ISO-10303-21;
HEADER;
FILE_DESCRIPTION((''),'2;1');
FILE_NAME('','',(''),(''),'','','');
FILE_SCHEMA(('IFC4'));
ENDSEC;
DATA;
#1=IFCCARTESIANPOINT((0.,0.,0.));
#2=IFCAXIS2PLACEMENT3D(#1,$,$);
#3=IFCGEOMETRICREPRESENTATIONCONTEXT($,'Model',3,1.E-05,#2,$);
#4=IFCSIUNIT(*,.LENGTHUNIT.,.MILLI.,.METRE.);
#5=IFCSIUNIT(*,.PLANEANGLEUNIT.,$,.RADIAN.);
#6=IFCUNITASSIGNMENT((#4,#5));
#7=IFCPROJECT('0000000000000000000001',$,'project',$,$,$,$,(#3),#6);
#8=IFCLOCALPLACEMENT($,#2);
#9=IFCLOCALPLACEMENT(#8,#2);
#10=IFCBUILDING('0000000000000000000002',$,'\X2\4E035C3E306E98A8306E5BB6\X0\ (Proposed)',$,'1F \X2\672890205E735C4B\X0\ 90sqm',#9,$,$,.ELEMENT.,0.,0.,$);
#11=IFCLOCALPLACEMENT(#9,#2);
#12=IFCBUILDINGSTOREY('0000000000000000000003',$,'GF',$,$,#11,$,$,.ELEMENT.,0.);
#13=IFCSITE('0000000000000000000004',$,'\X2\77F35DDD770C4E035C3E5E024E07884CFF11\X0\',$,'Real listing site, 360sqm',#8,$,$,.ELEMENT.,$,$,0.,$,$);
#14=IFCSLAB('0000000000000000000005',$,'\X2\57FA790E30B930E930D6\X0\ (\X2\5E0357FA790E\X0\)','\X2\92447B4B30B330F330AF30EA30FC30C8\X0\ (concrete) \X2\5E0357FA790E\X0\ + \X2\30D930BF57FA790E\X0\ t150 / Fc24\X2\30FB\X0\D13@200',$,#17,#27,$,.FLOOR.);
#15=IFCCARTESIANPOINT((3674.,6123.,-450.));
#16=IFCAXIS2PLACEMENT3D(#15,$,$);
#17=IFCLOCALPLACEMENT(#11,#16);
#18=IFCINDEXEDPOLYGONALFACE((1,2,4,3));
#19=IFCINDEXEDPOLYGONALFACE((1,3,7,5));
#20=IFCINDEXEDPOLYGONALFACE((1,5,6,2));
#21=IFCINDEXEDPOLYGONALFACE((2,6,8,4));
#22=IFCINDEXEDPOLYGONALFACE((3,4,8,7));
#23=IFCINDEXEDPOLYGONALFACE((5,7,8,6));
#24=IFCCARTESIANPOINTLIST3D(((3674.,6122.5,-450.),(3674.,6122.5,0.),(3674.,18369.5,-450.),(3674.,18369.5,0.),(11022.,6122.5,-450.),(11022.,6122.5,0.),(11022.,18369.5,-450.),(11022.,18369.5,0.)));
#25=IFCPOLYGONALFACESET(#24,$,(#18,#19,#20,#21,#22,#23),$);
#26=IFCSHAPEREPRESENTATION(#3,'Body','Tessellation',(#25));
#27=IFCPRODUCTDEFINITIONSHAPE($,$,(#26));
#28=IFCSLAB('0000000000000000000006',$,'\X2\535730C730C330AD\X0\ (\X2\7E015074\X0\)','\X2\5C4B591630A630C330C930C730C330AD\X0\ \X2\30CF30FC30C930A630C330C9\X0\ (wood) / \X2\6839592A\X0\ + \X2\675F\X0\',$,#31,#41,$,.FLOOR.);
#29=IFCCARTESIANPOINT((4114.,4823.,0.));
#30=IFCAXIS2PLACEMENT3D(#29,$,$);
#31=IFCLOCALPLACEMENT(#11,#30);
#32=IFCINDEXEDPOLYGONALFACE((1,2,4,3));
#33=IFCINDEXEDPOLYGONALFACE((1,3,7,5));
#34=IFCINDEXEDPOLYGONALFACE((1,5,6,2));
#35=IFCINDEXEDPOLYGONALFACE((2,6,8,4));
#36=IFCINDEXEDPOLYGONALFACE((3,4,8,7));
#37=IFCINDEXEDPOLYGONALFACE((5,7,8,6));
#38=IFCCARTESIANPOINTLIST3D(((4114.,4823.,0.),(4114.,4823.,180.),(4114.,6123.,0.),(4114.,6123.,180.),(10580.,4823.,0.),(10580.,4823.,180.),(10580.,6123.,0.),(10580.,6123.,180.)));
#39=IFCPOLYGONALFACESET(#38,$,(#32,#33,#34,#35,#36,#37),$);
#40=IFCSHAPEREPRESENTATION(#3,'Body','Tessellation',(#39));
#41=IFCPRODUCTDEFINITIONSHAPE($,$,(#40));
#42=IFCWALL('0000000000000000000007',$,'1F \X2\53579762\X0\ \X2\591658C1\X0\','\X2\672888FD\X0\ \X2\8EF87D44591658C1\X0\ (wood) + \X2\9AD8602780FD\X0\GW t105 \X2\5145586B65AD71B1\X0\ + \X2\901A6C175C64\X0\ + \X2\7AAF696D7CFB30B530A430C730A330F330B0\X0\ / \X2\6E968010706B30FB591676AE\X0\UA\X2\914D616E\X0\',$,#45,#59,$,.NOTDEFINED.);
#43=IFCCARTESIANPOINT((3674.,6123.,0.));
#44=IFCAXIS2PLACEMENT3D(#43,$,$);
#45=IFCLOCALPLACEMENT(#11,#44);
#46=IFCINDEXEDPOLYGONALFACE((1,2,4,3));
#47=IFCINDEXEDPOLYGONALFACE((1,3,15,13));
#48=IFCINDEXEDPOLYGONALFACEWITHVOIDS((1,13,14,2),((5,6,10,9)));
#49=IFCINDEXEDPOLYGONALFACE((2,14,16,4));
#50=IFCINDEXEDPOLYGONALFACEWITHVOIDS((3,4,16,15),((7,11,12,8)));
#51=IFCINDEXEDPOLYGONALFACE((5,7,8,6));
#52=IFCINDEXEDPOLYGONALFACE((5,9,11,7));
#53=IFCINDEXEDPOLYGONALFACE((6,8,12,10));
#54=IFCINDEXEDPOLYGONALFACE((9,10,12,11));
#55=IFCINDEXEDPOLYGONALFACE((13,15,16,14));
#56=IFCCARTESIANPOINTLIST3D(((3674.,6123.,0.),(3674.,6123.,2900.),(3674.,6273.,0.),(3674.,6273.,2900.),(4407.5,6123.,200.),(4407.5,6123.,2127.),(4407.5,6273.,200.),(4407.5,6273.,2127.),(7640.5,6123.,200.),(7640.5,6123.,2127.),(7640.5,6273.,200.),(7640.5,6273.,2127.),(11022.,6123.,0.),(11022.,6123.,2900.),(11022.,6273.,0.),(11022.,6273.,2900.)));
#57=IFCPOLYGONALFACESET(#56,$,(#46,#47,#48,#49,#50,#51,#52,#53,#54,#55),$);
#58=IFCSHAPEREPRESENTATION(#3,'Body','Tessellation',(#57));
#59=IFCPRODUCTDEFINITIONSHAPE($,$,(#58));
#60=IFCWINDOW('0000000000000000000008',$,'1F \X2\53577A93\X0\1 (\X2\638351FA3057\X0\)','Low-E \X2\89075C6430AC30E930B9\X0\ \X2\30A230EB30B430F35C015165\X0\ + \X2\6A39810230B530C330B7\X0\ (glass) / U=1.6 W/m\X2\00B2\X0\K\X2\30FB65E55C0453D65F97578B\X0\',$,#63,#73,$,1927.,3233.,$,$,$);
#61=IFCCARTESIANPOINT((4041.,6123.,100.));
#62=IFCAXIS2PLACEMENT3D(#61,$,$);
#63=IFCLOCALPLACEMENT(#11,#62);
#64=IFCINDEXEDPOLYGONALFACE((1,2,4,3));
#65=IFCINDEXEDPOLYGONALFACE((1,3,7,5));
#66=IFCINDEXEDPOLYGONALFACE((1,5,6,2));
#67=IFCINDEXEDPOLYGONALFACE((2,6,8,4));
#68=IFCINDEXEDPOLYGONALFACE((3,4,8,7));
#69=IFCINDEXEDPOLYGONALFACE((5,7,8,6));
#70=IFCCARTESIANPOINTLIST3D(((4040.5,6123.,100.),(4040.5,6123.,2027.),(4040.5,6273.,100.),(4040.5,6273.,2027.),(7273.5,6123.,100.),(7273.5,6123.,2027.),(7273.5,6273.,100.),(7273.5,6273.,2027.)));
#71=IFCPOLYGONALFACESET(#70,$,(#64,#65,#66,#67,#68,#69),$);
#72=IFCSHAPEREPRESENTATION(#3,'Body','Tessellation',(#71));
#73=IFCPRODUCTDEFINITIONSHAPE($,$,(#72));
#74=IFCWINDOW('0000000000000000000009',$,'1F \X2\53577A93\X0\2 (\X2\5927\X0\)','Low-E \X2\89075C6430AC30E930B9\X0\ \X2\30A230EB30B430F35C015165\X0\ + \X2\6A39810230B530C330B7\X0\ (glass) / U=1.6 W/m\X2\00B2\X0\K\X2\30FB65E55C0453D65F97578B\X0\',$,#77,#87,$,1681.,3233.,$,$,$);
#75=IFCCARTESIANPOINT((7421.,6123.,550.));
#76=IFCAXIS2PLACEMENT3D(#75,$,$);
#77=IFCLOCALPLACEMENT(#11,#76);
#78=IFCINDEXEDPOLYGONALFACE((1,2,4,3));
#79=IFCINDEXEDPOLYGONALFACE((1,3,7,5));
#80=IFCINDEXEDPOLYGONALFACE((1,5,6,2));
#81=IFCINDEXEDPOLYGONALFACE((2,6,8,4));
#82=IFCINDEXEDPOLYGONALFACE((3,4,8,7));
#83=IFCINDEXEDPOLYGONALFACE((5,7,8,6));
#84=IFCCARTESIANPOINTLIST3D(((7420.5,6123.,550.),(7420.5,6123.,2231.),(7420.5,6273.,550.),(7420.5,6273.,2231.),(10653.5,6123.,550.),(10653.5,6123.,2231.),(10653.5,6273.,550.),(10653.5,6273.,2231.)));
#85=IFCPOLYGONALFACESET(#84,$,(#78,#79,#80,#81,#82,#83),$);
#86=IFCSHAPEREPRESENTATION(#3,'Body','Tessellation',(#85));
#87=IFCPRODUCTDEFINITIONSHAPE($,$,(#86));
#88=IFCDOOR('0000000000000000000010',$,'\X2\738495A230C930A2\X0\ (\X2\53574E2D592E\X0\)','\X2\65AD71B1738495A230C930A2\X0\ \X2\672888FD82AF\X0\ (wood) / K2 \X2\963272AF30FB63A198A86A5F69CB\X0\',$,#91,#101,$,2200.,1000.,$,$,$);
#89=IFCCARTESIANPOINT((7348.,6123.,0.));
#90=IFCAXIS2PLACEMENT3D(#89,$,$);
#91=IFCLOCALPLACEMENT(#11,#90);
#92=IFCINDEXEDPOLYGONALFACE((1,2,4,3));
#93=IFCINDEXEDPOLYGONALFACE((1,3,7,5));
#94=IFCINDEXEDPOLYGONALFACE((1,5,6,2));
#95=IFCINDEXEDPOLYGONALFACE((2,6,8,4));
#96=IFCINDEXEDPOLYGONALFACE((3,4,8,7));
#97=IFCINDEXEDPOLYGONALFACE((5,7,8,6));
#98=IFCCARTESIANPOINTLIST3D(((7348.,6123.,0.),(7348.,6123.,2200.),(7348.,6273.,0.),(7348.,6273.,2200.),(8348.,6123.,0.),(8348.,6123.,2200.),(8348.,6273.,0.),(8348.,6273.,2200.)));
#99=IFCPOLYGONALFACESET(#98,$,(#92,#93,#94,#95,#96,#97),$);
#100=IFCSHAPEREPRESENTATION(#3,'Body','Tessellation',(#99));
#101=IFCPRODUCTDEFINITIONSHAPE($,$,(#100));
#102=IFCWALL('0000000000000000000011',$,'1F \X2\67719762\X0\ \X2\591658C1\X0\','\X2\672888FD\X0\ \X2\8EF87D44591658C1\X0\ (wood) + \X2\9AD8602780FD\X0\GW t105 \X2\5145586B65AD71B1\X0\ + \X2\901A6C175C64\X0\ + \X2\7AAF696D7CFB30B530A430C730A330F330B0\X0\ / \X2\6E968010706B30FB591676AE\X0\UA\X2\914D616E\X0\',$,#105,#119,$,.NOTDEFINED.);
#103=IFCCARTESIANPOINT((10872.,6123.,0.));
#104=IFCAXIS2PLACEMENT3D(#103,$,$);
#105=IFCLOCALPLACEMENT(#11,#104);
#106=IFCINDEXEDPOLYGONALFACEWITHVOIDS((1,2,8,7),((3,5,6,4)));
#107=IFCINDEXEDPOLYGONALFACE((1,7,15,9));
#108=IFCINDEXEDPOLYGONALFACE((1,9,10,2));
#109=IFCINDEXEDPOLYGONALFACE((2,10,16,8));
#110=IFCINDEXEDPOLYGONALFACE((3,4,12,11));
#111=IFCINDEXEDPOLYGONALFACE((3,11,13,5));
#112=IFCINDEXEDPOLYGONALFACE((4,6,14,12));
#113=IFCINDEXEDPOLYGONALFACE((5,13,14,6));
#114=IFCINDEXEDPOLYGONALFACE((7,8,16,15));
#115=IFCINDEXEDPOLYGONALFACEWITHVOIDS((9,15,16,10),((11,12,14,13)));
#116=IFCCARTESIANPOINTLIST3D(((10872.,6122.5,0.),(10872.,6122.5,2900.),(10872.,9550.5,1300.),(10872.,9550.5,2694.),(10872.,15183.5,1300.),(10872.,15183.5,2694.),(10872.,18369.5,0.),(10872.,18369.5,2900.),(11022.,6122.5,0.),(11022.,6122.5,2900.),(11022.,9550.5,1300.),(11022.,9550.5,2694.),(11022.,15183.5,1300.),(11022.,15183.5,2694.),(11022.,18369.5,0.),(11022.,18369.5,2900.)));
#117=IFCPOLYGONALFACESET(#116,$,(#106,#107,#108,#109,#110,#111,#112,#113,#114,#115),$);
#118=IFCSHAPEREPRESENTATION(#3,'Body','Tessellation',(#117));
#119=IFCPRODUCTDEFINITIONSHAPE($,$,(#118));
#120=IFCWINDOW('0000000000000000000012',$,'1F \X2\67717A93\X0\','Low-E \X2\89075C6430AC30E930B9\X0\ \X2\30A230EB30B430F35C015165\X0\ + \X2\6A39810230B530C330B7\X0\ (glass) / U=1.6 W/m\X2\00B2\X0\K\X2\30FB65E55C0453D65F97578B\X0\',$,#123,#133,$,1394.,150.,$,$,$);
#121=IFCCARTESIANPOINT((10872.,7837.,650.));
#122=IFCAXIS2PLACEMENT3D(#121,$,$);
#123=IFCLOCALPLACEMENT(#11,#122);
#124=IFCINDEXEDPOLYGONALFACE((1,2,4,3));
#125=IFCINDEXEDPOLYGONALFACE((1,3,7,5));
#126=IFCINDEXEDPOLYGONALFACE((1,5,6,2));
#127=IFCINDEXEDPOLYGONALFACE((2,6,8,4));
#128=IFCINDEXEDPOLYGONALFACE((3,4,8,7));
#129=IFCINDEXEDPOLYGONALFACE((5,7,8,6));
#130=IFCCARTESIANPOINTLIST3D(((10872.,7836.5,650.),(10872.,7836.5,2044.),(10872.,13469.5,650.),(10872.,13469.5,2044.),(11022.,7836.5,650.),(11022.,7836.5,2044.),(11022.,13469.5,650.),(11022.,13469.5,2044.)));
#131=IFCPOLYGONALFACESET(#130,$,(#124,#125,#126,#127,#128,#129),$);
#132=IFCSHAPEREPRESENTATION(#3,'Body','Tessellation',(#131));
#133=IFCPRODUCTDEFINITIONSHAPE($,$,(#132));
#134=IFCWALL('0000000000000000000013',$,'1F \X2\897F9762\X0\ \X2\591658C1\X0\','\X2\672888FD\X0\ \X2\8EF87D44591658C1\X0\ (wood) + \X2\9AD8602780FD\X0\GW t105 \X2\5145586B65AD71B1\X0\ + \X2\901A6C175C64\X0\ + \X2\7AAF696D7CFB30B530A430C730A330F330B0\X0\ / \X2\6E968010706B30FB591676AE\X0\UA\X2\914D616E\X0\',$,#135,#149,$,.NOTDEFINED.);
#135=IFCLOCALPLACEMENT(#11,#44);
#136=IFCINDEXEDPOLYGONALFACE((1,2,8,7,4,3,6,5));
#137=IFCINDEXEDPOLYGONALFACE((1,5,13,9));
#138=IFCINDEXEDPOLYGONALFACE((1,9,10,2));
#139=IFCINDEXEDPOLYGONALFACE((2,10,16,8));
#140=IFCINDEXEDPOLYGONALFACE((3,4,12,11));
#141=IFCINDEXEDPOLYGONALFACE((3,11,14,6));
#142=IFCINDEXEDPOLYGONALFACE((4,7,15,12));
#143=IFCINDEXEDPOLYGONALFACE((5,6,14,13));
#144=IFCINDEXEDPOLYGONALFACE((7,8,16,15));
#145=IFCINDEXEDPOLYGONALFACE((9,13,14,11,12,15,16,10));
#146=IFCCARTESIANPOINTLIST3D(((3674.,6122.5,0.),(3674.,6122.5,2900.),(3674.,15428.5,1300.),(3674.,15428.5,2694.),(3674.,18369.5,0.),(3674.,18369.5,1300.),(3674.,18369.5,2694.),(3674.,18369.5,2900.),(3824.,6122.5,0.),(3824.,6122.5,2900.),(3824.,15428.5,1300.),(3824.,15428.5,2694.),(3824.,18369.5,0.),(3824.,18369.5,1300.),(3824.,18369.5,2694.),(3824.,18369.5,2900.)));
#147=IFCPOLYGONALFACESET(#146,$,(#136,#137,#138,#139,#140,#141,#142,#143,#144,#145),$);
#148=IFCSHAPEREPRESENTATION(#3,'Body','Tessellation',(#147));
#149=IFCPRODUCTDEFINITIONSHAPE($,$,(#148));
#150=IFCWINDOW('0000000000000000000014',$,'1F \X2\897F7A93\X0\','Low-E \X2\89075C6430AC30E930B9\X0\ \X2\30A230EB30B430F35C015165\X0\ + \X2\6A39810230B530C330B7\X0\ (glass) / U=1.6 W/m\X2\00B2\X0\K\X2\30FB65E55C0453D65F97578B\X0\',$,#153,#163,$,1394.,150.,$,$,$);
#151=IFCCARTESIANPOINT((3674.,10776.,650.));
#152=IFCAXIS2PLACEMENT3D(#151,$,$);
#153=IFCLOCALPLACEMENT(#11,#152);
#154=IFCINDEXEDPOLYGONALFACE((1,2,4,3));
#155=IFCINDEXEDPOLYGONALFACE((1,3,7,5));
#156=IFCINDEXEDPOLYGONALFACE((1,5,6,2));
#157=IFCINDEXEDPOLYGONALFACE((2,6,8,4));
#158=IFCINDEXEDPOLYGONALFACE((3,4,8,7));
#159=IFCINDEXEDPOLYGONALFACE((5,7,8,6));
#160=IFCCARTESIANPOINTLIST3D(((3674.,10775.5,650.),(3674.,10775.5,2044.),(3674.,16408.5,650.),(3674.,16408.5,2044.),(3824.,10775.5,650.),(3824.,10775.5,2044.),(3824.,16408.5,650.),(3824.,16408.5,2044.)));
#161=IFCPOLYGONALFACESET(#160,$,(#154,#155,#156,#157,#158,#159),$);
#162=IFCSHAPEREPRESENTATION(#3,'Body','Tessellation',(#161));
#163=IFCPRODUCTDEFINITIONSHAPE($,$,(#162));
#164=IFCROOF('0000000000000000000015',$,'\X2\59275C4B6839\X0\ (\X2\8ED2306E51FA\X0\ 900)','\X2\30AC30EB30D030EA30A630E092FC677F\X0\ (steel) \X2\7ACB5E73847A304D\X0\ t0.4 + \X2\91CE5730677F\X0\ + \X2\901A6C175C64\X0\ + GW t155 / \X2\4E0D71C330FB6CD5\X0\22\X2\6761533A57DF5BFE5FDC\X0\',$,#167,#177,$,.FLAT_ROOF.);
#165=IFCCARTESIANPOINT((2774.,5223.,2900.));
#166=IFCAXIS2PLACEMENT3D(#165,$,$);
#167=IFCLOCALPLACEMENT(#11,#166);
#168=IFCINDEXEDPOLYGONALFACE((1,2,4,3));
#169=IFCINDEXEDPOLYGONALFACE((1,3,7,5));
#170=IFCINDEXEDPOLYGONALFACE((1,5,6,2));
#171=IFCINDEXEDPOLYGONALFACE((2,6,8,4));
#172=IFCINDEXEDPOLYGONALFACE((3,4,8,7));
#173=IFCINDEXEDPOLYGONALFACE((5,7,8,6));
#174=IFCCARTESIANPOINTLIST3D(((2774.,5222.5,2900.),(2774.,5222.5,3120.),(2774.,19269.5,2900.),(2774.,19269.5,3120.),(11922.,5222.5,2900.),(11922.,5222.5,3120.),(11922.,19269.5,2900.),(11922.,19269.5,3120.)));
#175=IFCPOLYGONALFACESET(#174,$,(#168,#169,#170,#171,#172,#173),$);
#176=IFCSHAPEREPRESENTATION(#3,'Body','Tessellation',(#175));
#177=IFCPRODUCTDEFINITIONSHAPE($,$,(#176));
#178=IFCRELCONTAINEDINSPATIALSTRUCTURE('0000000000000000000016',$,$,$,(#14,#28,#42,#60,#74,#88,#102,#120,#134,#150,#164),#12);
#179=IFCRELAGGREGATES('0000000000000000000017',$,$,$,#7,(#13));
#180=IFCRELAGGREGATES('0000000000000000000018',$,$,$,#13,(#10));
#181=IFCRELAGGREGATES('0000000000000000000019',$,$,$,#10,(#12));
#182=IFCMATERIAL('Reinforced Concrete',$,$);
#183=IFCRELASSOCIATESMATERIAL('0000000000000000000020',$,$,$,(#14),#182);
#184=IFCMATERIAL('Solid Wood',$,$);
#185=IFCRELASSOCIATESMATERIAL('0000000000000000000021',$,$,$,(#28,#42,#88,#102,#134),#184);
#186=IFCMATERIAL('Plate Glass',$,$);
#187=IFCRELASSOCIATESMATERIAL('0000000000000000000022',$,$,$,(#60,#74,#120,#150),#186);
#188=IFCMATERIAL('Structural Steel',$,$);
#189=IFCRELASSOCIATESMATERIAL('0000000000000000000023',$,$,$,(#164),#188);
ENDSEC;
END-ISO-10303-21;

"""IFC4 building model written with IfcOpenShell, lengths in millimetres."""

from ifc_helpers import new_model, si_unit, frame, frame_2d, origin, place, context, project, spatial, rectangle, extrude, material, element, fill, save


model = new_model("IFC4")

# Units and contexts
model_context = context("Model", 3, precision=1e-05, world=origin())
ifc_project = project(units=[si_unit("LENGTHUNIT", "METRE", prefix="MILLI"), si_unit("PLANEANGLEUNIT", "RADIAN")], contexts=[model_context])

# Site, building, storey
site_placement = place(None, origin())
site = spatial("IfcSite", under=ifc_project, at=site_placement, Name="石川県七尾市万行１", ObjectType="Real listing site, 360sqm", CompositionType="ELEMENT", RefElevation=0.0)
building_placement = place(site_placement, origin())
building = spatial("IfcBuilding", under=site, at=building_placement, Name="七尾の風の家 (Proposed)", ObjectType="1F 木造平屋 90sqm", CompositionType="ELEMENT", ElevationOfRefHeight=0.0, ElevationOfTerrain=0.0)
storey_placement = place(building_placement, origin())
storey = spatial("IfcBuildingStorey", under=building, at=storey_placement, Name="GF", CompositionType="ELEMENT", Elevation=0.0)

# Slabs
ifc_material_1 = material(Name="Reinforced Concrete")
slab_1_placement = place(storey_placement, frame((3674.0, 6123.0, -450.0)))
element("IfcSlab", 1, at=slab_1_placement, inside=storey, material=ifc_material_1, Name="基礎スラブ (布基礎)", Description="鉄筋コンクリート (concrete) 布基礎 + ベタ基礎 t150 / Fc24・D13@200", PredefinedType="FLOOR", context=model_context, shape_type="SweptSolid", body=[
    extrude(rectangle(XDim=7348.0, YDim=12247.0, at=frame_2d((3674.0, 6123.0))), frame((3674.0, 6123.0, -450.0)), (0.0, 0.0, 1.0), 450.0),
])
ifc_material_2 = material(Name="Solid Wood")
slab_2_placement = place(storey_placement, frame((4114.0, 4823.0, 0.0)))
element("IfcSlab", 2, at=slab_2_placement, inside=storey, material=ifc_material_2, Name="南デッキ (縁側)", Description="屋外ウッドデッキ ハードウッド (wood) / 根太 + 束", PredefinedType="FLOOR", context=model_context, shape_type="SweptSolid", body=[
    extrude(rectangle(XDim=6466.0, YDim=1300.0, at=frame_2d((3233.0, 650.0))), frame((4114.0, 4823.0, 0.0)), (0.0, 0.0, 1.0), 180.0),
])

# Wall, openings, windows, door
wall_1_placement = place(storey_placement, frame((3674.0, 6123.0, 0.0)))
wall_1 = element("IfcWall", 3, at=wall_1_placement, inside=storey, material=ifc_material_2, Name="1F 南面 外壁", Description="木製 軸組外壁 (wood) + 高性能GW t105 充填断熱 + 通気層 + 窯業系サイディング / 準耐火・外皮UA配慮", PredefinedType="NOTDEFINED", context=model_context, shape_type="SweptSolid", body=[
    extrude(rectangle(XDim=7348.0, YDim=150.0, at=frame_2d((3674.0, 75.0))), frame((3674.0, 6123.0, 0.0)), (0.0, 0.0, 1.0), 2900.0),
])
opening_1_placement = place(storey_placement, frame((4041.0, 6123.0, 100.0)))
opening_1 = element("IfcOpeningElement", 4, at=opening_1_placement, cuts=wall_1, PredefinedType="NOTDEFINED", context=model_context, shape_type="SweptSolid", body=[
    extrude(rectangle(XDim=3233.0, YDim=150.0, at=frame_2d((1616.0, 75.0))), frame((4041.0, 6123.0, 100.0)), (0.0, 0.0, 1.0), 1927.0),
])
opening_2_placement = place(storey_placement, frame((7421.0, 6123.0, 550.0)))
opening_2 = element("IfcOpeningElement", 5, at=opening_2_placement, cuts=wall_1, PredefinedType="NOTDEFINED", context=model_context, shape_type="SweptSolid", body=[
    extrude(rectangle(XDim=3233.0, YDim=150.0, at=frame_2d((1616.0, 75.0))), frame((7421.0, 6123.0, 550.0)), (0.0, 0.0, 1.0), 1681.0),
])
opening_3_placement = place(storey_placement, frame((7348.0, 6123.0, 0.0)))
opening_3 = element("IfcOpeningElement", 6, at=opening_3_placement, cuts=wall_1, PredefinedType="NOTDEFINED", context=model_context, shape_type="SweptSolid", body=[
    extrude(rectangle(XDim=1000.0, YDim=150.0, at=frame_2d((500.0, 75.0))), frame((7348.0, 6123.0, 0.0)), (0.0, 0.0, 1.0), 2200.0),
])
ifc_material_3 = material(Name="Plate Glass")
window_1_placement = place(storey_placement, frame((4041.0, 6123.0, 100.0)))
window_1 = element("IfcWindow", 7, at=window_1_placement, inside=storey, material=ifc_material_3, Name="1F 南窓1 (掃出し)", Description="Low-E 複層ガラス アルゴン封入 + 樹脂サッシ (glass) / U=1.6 W/m²K・日射取得型", OverallHeight=1927.0, OverallWidth=3233.0, context=model_context, shape_type="SweptSolid", body=[
    extrude(rectangle(XDim=3233.0, YDim=150.0, at=frame_2d((1616.0, 75.0))), frame((4041.0, 6123.0, 100.0)), (0.0, 0.0, 1.0), 1927.0),
])
fill(opening_1, window_1)
window_2_placement = place(storey_placement, frame((7421.0, 6123.0, 550.0)))
window_2 = element("IfcWindow", 8, at=window_2_placement, inside=storey, material=ifc_material_3, Name="1F 南窓2 (大)", Description="Low-E 複層ガラス アルゴン封入 + 樹脂サッシ (glass) / U=1.6 W/m²K・日射取得型", OverallHeight=1681.0, OverallWidth=3233.0, context=model_context, shape_type="SweptSolid", body=[
    extrude(rectangle(XDim=3233.0, YDim=150.0, at=frame_2d((1616.0, 75.0))), frame((7421.0, 6123.0, 550.0)), (0.0, 0.0, 1.0), 1681.0),
])
fill(opening_2, window_2)
door_placement = place(storey_placement, frame((7348.0, 6123.0, 0.0)))
door = element("IfcDoor", 9, at=door_placement, inside=storey, material=ifc_material_2, Name="玄関ドア (南中央)", Description="断熱玄関ドア 木製芯 (wood) / K2 防犯・採風機構", OverallHeight=2200.0, OverallWidth=1000.0, context=model_context, shape_type="SweptSolid", body=[
    extrude(rectangle(XDim=1000.0, YDim=150.0, at=frame_2d((500.0, 75.0))), frame((7348.0, 6123.0, 0.0)), (0.0, 0.0, 1.0), 2200.0),
])
fill(opening_3, door)

# Walls, openings, windows
wall_2_placement = place(storey_placement, frame((10872.0, 6123.0, 0.0)))
wall_2 = element("IfcWall", 10, at=wall_2_placement, inside=storey, material=ifc_material_2, Name="1F 東面 外壁", Description="木製 軸組外壁 (wood) + 高性能GW t105 充填断熱 + 通気層 + 窯業系サイディング / 準耐火・外皮UA配慮", PredefinedType="NOTDEFINED", context=model_context, shape_type="SweptSolid", body=[
    extrude(rectangle(XDim=150.0, YDim=12247.0, at=frame_2d((75.0, 6123.0))), frame((10872.0, 6123.0, 0.0)), (0.0, 0.0, 1.0), 2900.0),
])
opening_4_placement = place(storey_placement, frame((10872.0, 7837.0, 650.0)))
opening_4 = element("IfcOpeningElement", 11, at=opening_4_placement, cuts=wall_2, PredefinedType="NOTDEFINED", context=model_context, shape_type="SweptSolid", body=[
    extrude(rectangle(XDim=150.0, YDim=5633.0, at=frame_2d((75.0, 2816.0))), frame((10872.0, 7837.0, 650.0)), (0.0, 0.0, 1.0), 1394.0),
])
window_3_placement = place(storey_placement, frame((10872.0, 7837.0, 650.0)))
window_3 = element("IfcWindow", 12, at=window_3_placement, inside=storey, material=ifc_material_3, Name="1F 東窓", Description="Low-E 複層ガラス アルゴン封入 + 樹脂サッシ (glass) / U=1.6 W/m²K・日射取得型", OverallHeight=1394.0, OverallWidth=150.0, context=model_context, shape_type="SweptSolid", body=[
    extrude(rectangle(XDim=150.0, YDim=5633.0, at=frame_2d((75.0, 2816.0))), frame((10872.0, 7837.0, 650.0)), (0.0, 0.0, 1.0), 1394.0),
])
fill(opening_4, window_3)
wall_3_placement = place(storey_placement, frame((3674.0, 6123.0, 0.0)))
wall_3 = element("IfcWall", 13, at=wall_3_placement, inside=storey, material=ifc_material_2, Name="1F 西面 外壁", Description="木製 軸組外壁 (wood) + 高性能GW t105 充填断熱 + 通気層 + 窯業系サイディング / 準耐火・外皮UA配慮", PredefinedType="NOTDEFINED", context=model_context, shape_type="SweptSolid", body=[
    extrude(rectangle(XDim=150.0, YDim=12247.0, at=frame_2d((75.0, 6123.0))), frame((3674.0, 6123.0, 0.0)), (0.0, 0.0, 1.0), 2900.0),
])
opening_5_placement = place(storey_placement, frame((3674.0, 10776.0, 650.0)))
opening_5 = element("IfcOpeningElement", 14, at=opening_5_placement, cuts=wall_3, PredefinedType="NOTDEFINED", context=model_context, shape_type="SweptSolid", body=[
    extrude(rectangle(XDim=150.0, YDim=5633.0, at=frame_2d((75.0, 2816.0))), frame((3674.0, 10776.0, 650.0)), (0.0, 0.0, 1.0), 1394.0),
])
window_4_placement = place(storey_placement, frame((3674.0, 10776.0, 650.0)))
window_4 = element("IfcWindow", 15, at=window_4_placement, inside=storey, material=ifc_material_3, Name="1F 西窓", Description="Low-E 複層ガラス アルゴン封入 + 樹脂サッシ (glass) / U=1.6 W/m²K・日射取得型", OverallHeight=1394.0, OverallWidth=150.0, context=model_context, shape_type="SweptSolid", body=[
    extrude(rectangle(XDim=150.0, YDim=5633.0, at=frame_2d((75.0, 2816.0))), frame((3674.0, 10776.0, 650.0)), (0.0, 0.0, 1.0), 1394.0),
])
fill(opening_5, window_4)

# Roof
ifc_material_4 = material(Name="Structural Steel")
roof_placement = place(storey_placement, frame((2774.0, 5223.0, 2900.0)))
element("IfcRoof", 16, at=roof_placement, inside=storey, material=ifc_material_4, Name="大屋根 (軒の出 900)", Description="ガルバリウム鋼板 (steel) 立平葺き t0.4 + 野地板 + 通気層 + GW t155 / 不燃・法22条区域対応", PredefinedType="FLAT_ROOF", context=model_context, shape_type="SweptSolid", body=[
    extrude(rectangle(XDim=9148.0, YDim=14047.0, at=frame_2d((4574.0, 7023.0))), frame((2774.0, 5223.0, 2900.0)), (0.0, 0.0, 1.0), 220.0),
])

save(model, "model.ifc")
